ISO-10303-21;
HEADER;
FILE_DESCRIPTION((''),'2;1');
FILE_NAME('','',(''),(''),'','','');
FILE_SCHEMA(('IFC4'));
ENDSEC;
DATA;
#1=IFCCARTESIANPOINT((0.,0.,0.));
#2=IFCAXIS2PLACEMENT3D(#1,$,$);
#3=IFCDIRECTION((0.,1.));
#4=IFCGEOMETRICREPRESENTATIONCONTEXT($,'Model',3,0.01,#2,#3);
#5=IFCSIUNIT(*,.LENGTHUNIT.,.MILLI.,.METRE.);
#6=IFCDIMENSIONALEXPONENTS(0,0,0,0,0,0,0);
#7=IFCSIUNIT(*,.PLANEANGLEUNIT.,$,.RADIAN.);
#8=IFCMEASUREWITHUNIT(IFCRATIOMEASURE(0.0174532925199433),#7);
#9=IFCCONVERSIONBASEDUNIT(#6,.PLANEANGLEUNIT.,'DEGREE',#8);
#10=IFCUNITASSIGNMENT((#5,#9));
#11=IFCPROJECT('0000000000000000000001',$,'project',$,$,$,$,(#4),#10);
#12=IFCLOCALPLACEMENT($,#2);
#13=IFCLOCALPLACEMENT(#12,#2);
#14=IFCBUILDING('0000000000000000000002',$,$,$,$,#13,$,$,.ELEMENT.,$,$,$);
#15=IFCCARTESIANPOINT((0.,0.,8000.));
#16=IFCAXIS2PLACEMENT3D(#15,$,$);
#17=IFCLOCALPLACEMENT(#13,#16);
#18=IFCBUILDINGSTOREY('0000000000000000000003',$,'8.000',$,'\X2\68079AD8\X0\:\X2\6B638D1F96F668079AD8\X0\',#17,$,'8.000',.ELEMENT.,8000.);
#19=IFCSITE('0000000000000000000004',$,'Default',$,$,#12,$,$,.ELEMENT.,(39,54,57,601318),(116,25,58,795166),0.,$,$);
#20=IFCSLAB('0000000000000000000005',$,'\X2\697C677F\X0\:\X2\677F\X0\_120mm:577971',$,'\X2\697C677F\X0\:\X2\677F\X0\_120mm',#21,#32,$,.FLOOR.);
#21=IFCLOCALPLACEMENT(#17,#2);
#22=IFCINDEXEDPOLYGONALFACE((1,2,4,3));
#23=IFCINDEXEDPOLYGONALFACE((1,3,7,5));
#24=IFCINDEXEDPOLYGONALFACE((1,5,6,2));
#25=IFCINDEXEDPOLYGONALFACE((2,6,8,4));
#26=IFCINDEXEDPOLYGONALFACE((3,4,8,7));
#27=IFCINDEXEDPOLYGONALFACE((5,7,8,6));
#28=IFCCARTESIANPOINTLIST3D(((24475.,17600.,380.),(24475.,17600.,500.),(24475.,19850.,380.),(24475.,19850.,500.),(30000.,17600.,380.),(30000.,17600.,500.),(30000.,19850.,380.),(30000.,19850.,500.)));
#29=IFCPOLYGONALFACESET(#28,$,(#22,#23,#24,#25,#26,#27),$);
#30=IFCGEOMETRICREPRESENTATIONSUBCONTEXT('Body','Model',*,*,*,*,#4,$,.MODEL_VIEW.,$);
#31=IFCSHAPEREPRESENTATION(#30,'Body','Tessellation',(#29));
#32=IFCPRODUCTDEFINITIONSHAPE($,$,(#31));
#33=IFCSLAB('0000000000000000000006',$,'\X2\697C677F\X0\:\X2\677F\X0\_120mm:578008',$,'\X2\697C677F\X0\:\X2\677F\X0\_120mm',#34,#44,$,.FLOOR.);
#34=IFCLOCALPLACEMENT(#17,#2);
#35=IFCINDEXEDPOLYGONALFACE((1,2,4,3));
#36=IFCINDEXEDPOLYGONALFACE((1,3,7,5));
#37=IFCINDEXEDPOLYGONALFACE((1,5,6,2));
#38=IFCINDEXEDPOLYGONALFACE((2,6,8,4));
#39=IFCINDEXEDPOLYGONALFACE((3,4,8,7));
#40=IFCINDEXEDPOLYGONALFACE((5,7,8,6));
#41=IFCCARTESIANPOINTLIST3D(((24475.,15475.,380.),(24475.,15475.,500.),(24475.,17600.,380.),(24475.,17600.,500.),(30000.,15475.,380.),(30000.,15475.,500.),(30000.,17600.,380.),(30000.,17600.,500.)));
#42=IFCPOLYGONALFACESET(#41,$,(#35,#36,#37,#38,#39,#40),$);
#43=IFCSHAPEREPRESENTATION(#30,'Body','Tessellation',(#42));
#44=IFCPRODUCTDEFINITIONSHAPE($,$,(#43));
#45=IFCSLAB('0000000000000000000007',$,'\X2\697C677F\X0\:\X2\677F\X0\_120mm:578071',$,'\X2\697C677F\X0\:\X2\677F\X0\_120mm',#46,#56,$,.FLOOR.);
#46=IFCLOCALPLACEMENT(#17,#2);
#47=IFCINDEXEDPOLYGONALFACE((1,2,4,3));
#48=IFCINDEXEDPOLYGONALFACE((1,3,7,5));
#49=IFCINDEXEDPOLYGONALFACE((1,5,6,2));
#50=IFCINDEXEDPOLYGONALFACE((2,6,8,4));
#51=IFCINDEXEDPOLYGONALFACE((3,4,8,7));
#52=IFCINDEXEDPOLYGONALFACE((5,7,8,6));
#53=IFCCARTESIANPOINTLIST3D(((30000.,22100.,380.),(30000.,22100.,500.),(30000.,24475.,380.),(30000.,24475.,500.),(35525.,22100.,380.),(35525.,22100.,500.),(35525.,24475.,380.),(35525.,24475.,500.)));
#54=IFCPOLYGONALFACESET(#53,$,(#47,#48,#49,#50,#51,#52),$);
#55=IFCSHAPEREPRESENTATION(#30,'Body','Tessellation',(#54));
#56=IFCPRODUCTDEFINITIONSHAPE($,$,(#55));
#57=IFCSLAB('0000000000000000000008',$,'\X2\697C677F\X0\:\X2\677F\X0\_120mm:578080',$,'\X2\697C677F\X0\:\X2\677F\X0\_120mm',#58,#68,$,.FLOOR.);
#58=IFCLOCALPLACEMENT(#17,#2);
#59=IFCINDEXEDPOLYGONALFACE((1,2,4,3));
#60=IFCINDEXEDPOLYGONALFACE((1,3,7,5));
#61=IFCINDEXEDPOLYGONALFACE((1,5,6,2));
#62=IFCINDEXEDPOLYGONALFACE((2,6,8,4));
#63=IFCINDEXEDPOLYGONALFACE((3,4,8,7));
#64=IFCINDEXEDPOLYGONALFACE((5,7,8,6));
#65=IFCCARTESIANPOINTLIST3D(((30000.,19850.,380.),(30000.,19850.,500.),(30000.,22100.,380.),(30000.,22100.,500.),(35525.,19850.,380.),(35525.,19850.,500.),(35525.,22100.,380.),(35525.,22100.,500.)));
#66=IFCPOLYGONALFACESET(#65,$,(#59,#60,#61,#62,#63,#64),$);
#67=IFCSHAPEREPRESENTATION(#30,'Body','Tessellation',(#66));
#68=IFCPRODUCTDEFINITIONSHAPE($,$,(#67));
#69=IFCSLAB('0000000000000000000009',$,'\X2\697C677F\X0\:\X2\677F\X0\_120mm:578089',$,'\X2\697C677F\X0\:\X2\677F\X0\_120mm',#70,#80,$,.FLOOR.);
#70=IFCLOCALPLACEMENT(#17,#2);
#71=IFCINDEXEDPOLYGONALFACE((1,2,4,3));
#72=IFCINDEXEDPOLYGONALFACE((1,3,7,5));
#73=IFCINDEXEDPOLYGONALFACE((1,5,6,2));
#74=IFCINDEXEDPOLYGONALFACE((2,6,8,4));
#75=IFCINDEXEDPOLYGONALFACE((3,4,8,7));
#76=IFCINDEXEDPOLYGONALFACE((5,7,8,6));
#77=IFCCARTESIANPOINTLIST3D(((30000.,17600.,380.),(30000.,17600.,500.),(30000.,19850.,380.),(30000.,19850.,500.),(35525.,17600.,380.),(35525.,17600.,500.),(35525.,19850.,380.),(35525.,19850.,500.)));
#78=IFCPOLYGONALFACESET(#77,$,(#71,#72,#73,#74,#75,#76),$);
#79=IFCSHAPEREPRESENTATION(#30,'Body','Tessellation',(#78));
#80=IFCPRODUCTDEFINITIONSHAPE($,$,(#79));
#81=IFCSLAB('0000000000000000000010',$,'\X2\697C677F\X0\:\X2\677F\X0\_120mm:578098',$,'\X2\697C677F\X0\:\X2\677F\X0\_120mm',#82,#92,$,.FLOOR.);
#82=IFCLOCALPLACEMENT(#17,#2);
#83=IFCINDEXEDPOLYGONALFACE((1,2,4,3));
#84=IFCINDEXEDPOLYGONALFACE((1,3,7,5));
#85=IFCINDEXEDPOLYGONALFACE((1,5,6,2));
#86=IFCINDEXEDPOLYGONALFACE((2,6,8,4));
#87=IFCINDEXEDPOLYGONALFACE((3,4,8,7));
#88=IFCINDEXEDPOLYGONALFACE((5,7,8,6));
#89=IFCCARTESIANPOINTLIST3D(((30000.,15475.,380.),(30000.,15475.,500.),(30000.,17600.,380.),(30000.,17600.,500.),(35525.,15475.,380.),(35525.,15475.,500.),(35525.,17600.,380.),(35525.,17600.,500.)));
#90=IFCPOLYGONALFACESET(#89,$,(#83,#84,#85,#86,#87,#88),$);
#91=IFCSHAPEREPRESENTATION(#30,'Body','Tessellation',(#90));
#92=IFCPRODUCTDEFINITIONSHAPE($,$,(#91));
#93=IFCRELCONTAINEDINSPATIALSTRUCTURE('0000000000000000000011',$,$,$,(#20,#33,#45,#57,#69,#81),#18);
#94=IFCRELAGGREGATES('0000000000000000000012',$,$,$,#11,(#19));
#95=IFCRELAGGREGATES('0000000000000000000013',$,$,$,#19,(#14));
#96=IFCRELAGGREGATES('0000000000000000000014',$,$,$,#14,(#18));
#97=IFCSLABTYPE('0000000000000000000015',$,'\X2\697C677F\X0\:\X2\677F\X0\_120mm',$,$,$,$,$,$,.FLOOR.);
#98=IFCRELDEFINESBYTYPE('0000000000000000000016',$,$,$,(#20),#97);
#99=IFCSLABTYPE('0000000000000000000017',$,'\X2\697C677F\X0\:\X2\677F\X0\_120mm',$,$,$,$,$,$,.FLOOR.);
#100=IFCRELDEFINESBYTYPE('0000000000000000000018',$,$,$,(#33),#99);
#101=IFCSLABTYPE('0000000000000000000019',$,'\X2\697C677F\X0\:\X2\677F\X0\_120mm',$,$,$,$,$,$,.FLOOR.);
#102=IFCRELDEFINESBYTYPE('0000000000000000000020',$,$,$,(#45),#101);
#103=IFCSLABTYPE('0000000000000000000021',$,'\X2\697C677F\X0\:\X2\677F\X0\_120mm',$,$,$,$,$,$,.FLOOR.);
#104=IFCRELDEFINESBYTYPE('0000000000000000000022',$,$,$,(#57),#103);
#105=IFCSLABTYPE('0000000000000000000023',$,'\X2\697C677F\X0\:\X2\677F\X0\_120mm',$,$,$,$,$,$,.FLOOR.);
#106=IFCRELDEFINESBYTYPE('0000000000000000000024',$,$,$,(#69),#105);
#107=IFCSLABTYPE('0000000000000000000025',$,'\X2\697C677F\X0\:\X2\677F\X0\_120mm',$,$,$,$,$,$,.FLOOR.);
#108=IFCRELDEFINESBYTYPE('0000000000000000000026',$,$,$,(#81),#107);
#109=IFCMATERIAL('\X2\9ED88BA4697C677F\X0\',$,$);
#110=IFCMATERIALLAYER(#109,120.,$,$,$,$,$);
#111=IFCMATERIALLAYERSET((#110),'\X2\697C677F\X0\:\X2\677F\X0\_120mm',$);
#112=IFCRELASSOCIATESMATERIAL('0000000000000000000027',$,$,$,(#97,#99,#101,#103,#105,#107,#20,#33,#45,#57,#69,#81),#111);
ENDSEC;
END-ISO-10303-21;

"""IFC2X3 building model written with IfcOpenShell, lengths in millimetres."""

from ifc_helpers import new_model, entity, si_unit, converted_unit, direction, frame, frame_2d, origin, origin_2d_with_axis, place, context, subcontext, project, spatial, rectangle, extrude, material, layer, layer_set, layer_usage, type_object, element, save


model = new_model("IFC2X3")

# Units and contexts
model_context = context("Model", 3, precision=0.01, world=origin(), true_north=direction((0.0, 1.0)))
body_context = subcontext(model_context, "Body", "Model", "MODEL_VIEW")
ifc_project = project(units=[si_unit("LENGTHUNIT", "METRE", prefix="MILLI"), converted_unit("PLANEANGLEUNIT", "DEGREE", entity("IfcRatioMeasure", 0.0174532925199433), si_unit("PLANEANGLEUNIT", "RADIAN"), dimensions=[0, 0, 0, 0, 0, 0, 0])], contexts=[model_context])

# Site, building, storey
site_placement = place(None, origin())
site = spatial("IfcSite", under=ifc_project, at=site_placement, Name="Default", CompositionType="ELEMENT", RefLatitude=(39, 54, 57, 601318), RefLongitude=(116, 25, 58, 795166), RefElevation=0.0)
building_placement = place(site_placement, origin())
building = spatial("IfcBuilding", under=site, at=building_placement, CompositionType="ELEMENT")
storey_placement = place(building_placement, frame((0.0, 0.0, 8000.0)))
storey = spatial("IfcBuildingStorey", under=building, at=storey_placement, Name="8.000", ObjectType="标高:正负零标高", LongName="8.000", CompositionType="ELEMENT", Elevation=8000.0)

# Slabs
ifc_material_1 = material(Name="默认楼板")
ifc_layer_1 = layer(ifc_material_1, 120.0)
ifc_layer_set_1 = layer_set([ifc_layer_1], Name="楼板:板_120mm")
ifc_layer_usage_1 = layer_usage(ifc_layer_set_1, "AXIS3", "POSITIVE", 0.0)
slab_type_1 = type_object("IfcSlabType", Name="楼板:板_120mm", PredefinedType="FLOOR", material=ifc_layer_set_1)
slab_1_placement = place(storey_placement, origin())
element("IfcSlab", 1, at=slab_1_placement, inside=storey, type_object=slab_type_1, material=ifc_layer_usage_1, Name="楼板:板_120mm:577971", ObjectType="楼板:板_120mm", PredefinedType="FLOOR", context=body_context, shape_type="SweptSolid", body=[
    extrude(rectangle(XDim=2250.0, YDim=5525.0, at=origin_2d_with_axis()), frame((27237.5, 18725.0, 500.0), z_axis=(0.0, 0.0, -1.0), x_axis=(0.0, 1.0, 0.0)), (0.0, 0.0, 1.0), 120.0),
])
ifc_layer_usage_2 = layer_usage(ifc_layer_set_1, "AXIS3", "POSITIVE", 0.0)
slab_type_2 = type_object("IfcSlabType", Name="楼板:板_120mm", PredefinedType="FLOOR", material=ifc_layer_set_1)
slab_2_placement = place(storey_placement, origin())
element("IfcSlab", 2, at=slab_2_placement, inside=storey, type_object=slab_type_2, material=ifc_layer_usage_2, Name="楼板:板_120mm:578008", ObjectType="楼板:板_120mm", PredefinedType="FLOOR", context=body_context, shape_type="SweptSolid", body=[
    extrude(rectangle(XDim=2125.0, YDim=5525.0, at=frame_2d((0.0, 0.0), x_axis=(1.0, 0.0))), frame((27237.5, 16537.5, 500.0), z_axis=(0.0, 0.0, -1.0), x_axis=(0.0, 1.0, 0.0)), (0.0, 0.0, 1.0), 120.0),
])
ifc_layer_usage_3 = layer_usage(ifc_layer_set_1, "AXIS3", "POSITIVE", 0.0)
slab_type_3 = type_object("IfcSlabType", Name="楼板:板_120mm", PredefinedType="FLOOR", material=ifc_layer_set_1)
slab_3_placement = place(storey_placement, origin())
element("IfcSlab", 3, at=slab_3_placement, inside=storey, type_object=slab_type_3, material=ifc_layer_usage_3, Name="楼板:板_120mm:578071", ObjectType="楼板:板_120mm", PredefinedType="FLOOR", context=body_context, shape_type="SweptSolid", body=[
    extrude(rectangle(XDim=2375.0, YDim=5525.0, at=origin_2d_with_axis()), frame((32762.5, 23287.5, 500.0), z_axis=(0.0, 0.0, -1.0), x_axis=(0.0, 1.0, 0.0)), (0.0, 0.0, 1.0), 120.0),
])
ifc_layer_usage_4 = layer_usage(ifc_layer_set_1, "AXIS3", "POSITIVE", 0.0)
slab_type_4 = type_object("IfcSlabType", Name="楼板:板_120mm", PredefinedType="FLOOR", material=ifc_layer_set_1)
slab_4_placement = place(storey_placement, origin())
element("IfcSlab", 4, at=slab_4_placement, inside=storey, type_object=slab_type_4, material=ifc_layer_usage_4, Name="楼板:板_120mm:578080", ObjectType="楼板:板_120mm", PredefinedType="FLOOR", context=body_context, shape_type="SweptSolid", body=[
    extrude(rectangle(XDim=2250.0, YDim=5525.0, at=origin_2d_with_axis()), frame((32762.5, 20975.0, 500.0), z_axis=(0.0, 0.0, -1.0), x_axis=(0.0, 1.0, 0.0)), (0.0, 0.0, 1.0), 120.0),
])
ifc_layer_usage_5 = layer_usage(ifc_layer_set_1, "AXIS3", "POSITIVE", 0.0)
slab_type_5 = type_object("IfcSlabType", Name="楼板:板_120mm", PredefinedType="FLOOR", material=ifc_layer_set_1)
slab_5_placement = place(storey_placement, origin())
element("IfcSlab", 5, at=slab_5_placement, inside=storey, type_object=slab_type_5, material=ifc_layer_usage_5, Name="楼板:板_120mm:578089", ObjectType="楼板:板_120mm", PredefinedType="FLOOR", context=body_context, shape_type="SweptSolid", body=[
    extrude(rectangle(XDim=2250.0, YDim=5525.0, at=origin_2d_with_axis()), frame((32762.5, 18725.0, 500.0), z_axis=(0.0, 0.0, -1.0), x_axis=(0.0, 1.0, 0.0)), (0.0, 0.0, 1.0), 120.0),
])
ifc_layer_usage_6 = layer_usage(ifc_layer_set_1, "AXIS3", "POSITIVE", 0.0)
slab_type_6 = type_object("IfcSlabType", Name="楼板:板_120mm", PredefinedType="FLOOR", material=ifc_layer_set_1)
slab_6_placement = place(storey_placement, origin())
element("IfcSlab", 6, at=slab_6_placement, inside=storey, type_object=slab_type_6, material=ifc_layer_usage_6, Name="楼板:板_120mm:578098", ObjectType="楼板:板_120mm", PredefinedType="FLOOR", context=body_context, shape_type="SweptSolid", body=[
    extrude(rectangle(XDim=2125.0, YDim=5525.0, at=frame_2d((0.0, 0.0), x_axis=(1.0, 0.0))), frame((32762.5, 16537.5, 500.0), z_axis=(0.0, 0.0, -1.0), x_axis=(0.0, 1.0, 0.0)), (0.0, 0.0, 1.0), 120.0),
])

save(model, "model.ifc")
